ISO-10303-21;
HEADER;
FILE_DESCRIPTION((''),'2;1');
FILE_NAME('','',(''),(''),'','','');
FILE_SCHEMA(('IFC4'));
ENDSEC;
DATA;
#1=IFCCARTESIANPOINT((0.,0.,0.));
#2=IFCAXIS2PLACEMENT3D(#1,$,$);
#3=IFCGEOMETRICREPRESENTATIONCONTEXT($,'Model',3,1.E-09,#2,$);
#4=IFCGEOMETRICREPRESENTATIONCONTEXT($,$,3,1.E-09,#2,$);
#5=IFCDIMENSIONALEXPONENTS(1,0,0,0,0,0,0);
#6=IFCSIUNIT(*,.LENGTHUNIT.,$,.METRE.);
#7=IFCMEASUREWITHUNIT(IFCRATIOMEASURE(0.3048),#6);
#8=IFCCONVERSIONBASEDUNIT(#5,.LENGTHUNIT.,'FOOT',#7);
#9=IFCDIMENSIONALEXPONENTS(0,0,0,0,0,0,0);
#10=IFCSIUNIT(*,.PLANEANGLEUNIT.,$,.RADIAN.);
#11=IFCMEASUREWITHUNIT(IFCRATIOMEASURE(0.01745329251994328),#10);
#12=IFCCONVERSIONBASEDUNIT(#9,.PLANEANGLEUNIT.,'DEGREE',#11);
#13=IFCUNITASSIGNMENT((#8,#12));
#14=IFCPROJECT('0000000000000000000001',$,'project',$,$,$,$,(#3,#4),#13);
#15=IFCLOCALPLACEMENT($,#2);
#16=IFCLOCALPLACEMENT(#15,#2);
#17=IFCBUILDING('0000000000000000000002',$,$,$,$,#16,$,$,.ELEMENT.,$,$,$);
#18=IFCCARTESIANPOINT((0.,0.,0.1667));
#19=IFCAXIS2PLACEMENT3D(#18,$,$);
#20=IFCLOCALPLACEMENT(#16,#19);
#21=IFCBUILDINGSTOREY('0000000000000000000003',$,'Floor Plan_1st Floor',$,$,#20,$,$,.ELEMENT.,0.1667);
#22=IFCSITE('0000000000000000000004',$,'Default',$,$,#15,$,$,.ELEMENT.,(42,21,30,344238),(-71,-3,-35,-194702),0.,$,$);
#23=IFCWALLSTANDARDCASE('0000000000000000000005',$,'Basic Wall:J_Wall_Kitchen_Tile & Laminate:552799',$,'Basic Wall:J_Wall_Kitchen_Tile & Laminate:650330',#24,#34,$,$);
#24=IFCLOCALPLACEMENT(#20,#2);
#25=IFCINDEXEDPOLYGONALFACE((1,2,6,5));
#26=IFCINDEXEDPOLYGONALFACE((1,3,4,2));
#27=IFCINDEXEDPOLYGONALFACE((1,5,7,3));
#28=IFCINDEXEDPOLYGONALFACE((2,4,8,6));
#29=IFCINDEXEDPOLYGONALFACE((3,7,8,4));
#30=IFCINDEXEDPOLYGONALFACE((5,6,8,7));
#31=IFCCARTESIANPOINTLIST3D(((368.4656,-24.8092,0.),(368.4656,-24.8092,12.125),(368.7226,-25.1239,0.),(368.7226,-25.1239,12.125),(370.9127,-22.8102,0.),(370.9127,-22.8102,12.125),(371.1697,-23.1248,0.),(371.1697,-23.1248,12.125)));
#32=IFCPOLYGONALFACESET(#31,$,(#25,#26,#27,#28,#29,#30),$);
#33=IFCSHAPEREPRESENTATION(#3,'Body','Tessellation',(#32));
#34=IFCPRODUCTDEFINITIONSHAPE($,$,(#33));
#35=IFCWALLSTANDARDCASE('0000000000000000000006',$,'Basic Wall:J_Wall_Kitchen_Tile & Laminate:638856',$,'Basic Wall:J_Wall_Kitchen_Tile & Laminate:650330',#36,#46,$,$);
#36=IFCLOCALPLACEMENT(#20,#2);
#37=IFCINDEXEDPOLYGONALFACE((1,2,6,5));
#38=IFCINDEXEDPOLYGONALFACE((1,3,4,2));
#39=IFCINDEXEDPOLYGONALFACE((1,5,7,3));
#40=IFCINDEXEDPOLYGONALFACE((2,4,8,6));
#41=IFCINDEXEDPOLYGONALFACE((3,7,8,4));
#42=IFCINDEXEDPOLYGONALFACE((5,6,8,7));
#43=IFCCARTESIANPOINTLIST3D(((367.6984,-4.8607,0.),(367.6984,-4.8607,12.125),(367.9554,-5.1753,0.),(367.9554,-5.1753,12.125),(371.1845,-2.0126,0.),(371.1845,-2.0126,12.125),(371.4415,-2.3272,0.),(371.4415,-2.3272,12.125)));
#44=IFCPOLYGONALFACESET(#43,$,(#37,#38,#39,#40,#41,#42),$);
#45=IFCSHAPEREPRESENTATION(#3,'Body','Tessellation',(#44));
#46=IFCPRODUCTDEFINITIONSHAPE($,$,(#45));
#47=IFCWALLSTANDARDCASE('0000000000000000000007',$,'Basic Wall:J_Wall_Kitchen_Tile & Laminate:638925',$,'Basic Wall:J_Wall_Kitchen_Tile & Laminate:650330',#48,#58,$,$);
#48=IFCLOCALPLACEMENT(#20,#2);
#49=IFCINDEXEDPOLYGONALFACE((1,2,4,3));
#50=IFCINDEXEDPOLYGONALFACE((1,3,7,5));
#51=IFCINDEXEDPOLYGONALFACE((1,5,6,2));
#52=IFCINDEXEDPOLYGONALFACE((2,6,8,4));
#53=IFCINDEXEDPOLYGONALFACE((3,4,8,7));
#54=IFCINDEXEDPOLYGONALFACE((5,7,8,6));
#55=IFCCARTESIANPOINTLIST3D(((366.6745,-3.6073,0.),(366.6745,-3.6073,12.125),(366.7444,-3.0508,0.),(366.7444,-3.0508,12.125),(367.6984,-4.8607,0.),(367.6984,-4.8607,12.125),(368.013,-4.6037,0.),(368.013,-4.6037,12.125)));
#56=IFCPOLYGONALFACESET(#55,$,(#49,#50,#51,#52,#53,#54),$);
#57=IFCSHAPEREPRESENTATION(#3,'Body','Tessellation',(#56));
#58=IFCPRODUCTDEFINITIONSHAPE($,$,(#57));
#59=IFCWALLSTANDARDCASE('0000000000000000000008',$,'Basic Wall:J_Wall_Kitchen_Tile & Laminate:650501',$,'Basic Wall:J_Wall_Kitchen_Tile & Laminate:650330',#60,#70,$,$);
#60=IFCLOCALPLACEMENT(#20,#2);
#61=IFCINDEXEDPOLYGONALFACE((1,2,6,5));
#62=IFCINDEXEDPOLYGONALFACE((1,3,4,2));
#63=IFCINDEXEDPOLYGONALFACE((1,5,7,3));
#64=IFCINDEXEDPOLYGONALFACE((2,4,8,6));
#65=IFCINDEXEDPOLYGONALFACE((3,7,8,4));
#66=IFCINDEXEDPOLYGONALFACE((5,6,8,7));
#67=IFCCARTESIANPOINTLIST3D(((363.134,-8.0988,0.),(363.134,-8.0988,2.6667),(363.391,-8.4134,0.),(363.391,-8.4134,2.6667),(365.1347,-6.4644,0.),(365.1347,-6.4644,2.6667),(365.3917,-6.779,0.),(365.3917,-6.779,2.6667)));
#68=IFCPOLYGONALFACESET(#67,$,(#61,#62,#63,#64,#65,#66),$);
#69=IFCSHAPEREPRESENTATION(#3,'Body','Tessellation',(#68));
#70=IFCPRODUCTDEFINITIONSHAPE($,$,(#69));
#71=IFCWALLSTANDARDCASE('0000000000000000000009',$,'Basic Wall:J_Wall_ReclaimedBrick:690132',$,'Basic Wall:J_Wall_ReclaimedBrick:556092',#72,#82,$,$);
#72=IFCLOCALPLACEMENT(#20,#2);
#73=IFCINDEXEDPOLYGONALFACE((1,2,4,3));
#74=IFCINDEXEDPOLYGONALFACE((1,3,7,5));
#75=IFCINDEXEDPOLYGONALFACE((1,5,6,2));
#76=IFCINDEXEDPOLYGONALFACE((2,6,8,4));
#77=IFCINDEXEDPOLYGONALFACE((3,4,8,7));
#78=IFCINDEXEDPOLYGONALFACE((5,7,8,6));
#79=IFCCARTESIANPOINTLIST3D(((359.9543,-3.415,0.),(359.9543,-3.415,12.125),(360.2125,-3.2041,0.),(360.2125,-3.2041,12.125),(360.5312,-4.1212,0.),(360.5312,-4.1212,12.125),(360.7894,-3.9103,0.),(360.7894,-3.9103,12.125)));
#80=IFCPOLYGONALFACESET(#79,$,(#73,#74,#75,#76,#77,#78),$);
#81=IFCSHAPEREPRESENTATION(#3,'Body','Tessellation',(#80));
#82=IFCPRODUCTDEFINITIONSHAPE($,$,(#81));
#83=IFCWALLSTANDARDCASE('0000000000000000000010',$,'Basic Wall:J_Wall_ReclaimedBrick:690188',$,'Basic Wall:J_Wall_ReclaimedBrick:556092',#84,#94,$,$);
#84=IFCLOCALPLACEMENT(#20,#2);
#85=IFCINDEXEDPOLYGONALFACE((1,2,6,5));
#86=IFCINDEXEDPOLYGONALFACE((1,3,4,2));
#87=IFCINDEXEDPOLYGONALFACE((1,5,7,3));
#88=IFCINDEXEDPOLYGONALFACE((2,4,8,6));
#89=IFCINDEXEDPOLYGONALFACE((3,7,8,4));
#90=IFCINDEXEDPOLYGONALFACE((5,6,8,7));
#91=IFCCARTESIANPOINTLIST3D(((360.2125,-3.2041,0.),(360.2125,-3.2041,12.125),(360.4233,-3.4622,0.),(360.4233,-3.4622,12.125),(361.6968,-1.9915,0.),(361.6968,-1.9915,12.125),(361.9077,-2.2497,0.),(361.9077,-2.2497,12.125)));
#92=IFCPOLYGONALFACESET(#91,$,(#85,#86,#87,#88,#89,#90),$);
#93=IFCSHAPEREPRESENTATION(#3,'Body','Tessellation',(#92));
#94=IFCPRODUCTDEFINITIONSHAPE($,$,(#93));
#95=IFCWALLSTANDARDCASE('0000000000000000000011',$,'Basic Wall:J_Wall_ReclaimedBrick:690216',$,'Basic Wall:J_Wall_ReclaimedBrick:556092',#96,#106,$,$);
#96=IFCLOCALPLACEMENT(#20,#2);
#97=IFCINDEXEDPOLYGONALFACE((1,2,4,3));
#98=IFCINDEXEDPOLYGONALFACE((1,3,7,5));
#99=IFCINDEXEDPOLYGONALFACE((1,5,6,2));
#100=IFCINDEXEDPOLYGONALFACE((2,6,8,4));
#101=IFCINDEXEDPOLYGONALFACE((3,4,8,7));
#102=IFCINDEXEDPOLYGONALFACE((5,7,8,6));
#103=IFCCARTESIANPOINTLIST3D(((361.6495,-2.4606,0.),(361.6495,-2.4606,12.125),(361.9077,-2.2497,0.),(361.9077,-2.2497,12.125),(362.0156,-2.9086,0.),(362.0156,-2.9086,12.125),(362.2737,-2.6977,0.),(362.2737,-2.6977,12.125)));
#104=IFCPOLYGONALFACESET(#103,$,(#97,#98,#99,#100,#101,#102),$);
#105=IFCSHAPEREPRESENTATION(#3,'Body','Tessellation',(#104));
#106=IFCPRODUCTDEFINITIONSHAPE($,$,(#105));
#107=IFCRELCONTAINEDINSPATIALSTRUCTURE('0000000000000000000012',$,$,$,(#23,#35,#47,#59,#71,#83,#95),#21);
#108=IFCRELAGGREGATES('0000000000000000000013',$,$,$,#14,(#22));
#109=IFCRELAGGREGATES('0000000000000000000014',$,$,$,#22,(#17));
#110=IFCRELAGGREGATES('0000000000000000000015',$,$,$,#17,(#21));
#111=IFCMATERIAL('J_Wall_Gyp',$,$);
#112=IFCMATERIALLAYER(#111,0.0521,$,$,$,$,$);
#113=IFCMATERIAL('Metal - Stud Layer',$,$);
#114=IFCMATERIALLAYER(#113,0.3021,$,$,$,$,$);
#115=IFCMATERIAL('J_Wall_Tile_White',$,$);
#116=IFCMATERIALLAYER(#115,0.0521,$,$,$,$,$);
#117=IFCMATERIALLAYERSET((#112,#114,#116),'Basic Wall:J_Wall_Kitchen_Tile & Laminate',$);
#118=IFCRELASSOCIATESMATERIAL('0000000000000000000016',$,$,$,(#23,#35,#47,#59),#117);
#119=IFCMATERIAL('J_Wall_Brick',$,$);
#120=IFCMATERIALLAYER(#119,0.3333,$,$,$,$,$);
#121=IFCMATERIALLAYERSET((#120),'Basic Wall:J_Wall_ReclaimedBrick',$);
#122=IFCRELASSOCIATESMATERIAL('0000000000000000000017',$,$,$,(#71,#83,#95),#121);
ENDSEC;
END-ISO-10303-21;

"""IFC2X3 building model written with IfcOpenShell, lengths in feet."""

from ifc_helpers import new_model, entity, si_unit, converted_unit, frame, frame_2d, origin, place, context, project, spatial, polyline, rectangle, outline, extrude, material, layer, layer_set, layer_usage, element, save


model = new_model("IFC2X3")

# Units and contexts
model_context = context("Model", 3, precision=1e-09, world=origin())
context_of_model = context(None, 3, precision=1e-09, world=origin())
ifc_project = project(units=[converted_unit("LENGTHUNIT", "FOOT", entity("IfcRatioMeasure", 0.3048), si_unit("LENGTHUNIT", "METRE"), dimensions=[1, 0, 0, 0, 0, 0, 0]), converted_unit("PLANEANGLEUNIT", "DEGREE", entity("IfcRatioMeasure", 0.01745329251994328), si_unit("PLANEANGLEUNIT", "RADIAN"), dimensions=[0, 0, 0, 0, 0, 0, 0])], contexts=[model_context, context_of_model])

# Site, building, storey
site_placement = place(None, origin())
site = spatial("IfcSite", under=ifc_project, at=site_placement, Name="Default", CompositionType="ELEMENT", RefLatitude=(42, 21, 30, 344238), RefLongitude=(-71, -3, -35, -194702), RefElevation=0.0)
building_placement = place(site_placement, origin())
building = spatial("IfcBuilding", under=site, at=building_placement, CompositionType="ELEMENT")
storey_placement = place(building_placement, frame((0.0, 0.0, 0.1667)))
storey = spatial("IfcBuildingStorey", under=building, at=storey_placement, Name="Floor Plan_1st Floor", CompositionType="ELEMENT", Elevation=0.1667)

# Shared definitions
ifc_material_1 = material(Name="J_Wall_Gyp")
ifc_layer_1 = layer(ifc_material_1, 0.0521)
ifc_material_2 = material(Name="Metal - Stud Layer")
ifc_layer_2 = layer(ifc_material_2, 0.3021)
ifc_material_3 = material(Name="J_Wall_Tile_White")
ifc_layer_3 = layer(ifc_material_3, 0.0521)
ifc_layer_set_1 = layer_set([ifc_layer_1, ifc_layer_2, ifc_layer_3], Name="Basic Wall:J_Wall_Kitchen_Tile & Laminate")

# Shared definitions
ifc_material_4 = material(Name="J_Wall_Brick")
ifc_layer_4 = layer(ifc_material_4, 0.3333)
ifc_layer_set_2 = layer_set([ifc_layer_4], Name="Basic Wall:J_Wall_ReclaimedBrick")

# Walls
ifc_layer_usage_1 = layer_usage(ifc_layer_set_1, "AXIS2", "POSITIVE", -0.2031)
wall_1_placement = place(storey_placement, frame((371.0412, -22.9675, 0.0), z_axis=(0.0, 0.0, 1.0), x_axis=(-0.774444, -0.632643, 0.0)))
element("IfcWallStandardCase", 1, at=wall_1_placement, inside=storey, material=ifc_layer_usage_1, Name="Basic Wall:J_Wall_Kitchen_Tile & Laminate:552799", ObjectType="Basic Wall:J_Wall_Kitchen_Tile & Laminate:650330", context=model_context, shape_type="SweptSolid", body=[
    extrude(rectangle(XDim=3.1598, YDim=0.4063, at=frame_2d((1.5799, 0.0), x_axis=(-1.0, 0.0))), origin(), (0.0, 0.0, 1.0), 12.125),
])
ifc_layer_usage_2 = layer_usage(ifc_layer_set_1, "AXIS2", "POSITIVE", -0.2031)
wall_2_placement = place(storey_placement, frame((371.313, -2.1699, 0.0), z_axis=(0.0, 0.0, 1.0), x_axis=(-0.774414, -0.63268, 0.0)))
element("IfcWallStandardCase", 2, at=wall_2_placement, inside=storey, material=ifc_layer_usage_2, Name="Basic Wall:J_Wall_Kitchen_Tile & Laminate:638856", ObjectType="Basic Wall:J_Wall_Kitchen_Tile & Laminate:650330", context=model_context, shape_type="SweptSolid", body=[
    extrude(rectangle(XDim=4.5016, YDim=0.4063, at=frame_2d((2.2508, 0.0), x_axis=(-1.0, 0.0))), origin(), (0.0, 0.0, 1.0), 12.125),
])
ifc_layer_usage_3 = layer_usage(ifc_layer_set_1, "AXIS2", "NEGATIVE", 0.2031)
wall_3_placement = place(storey_placement, frame((366.5871, -3.1793, 0.0), z_axis=(0.0, 0.0, 1.0), x_axis=(0.632643, -0.774444, 0.0)))
element("IfcWallStandardCase", 3, at=wall_3_placement, inside=storey, material=ifc_layer_usage_3, Name="Basic Wall:J_Wall_Kitchen_Tile & Laminate:638925", ObjectType="Basic Wall:J_Wall_Kitchen_Tile & Laminate:650330", context=model_context, shape_type="SweptSolid", body=[
    extrude(outline(polyline([(2.0051, -0.2031), (2.0051, 0.2031), (0.0, 0.2031), (0.3867, -0.2031), (2.0051, -0.2031)])), origin(), (0.0, 0.0, 1.0), 12.125),
])
ifc_layer_usage_4 = layer_usage(ifc_layer_set_1, "AXIS2", "POSITIVE", -0.2031)
wall_4_placement = place(storey_placement, frame((365.2632, -6.6217, 0.0), z_axis=(0.0, 0.0, 1.0), x_axis=(-0.774444, -0.632643, 0.0)))
element("IfcWallStandardCase", 4, at=wall_4_placement, inside=storey, material=ifc_layer_usage_4, Name="Basic Wall:J_Wall_Kitchen_Tile & Laminate:650501", ObjectType="Basic Wall:J_Wall_Kitchen_Tile & Laminate:650330", context=model_context, shape_type="SweptSolid", body=[
    extrude(rectangle(XDim=2.5834, YDim=0.4063, at=frame_2d((1.2917, 0.0), x_axis=(-1.0, 0.0))), origin(), (0.0, 0.0, 1.0), 2.6667),
])
ifc_layer_usage_5 = layer_usage(ifc_layer_set_2, "AXIS2", "NEGATIVE", 0.1667)
wall_5_placement = place(storey_placement, frame((360.6603, -4.0157, 0.0), z_axis=(0.0, 0.0, 1.0), x_axis=(-0.632643, 0.774444, 0.0)))
element("IfcWallStandardCase", 5, at=wall_5_placement, inside=storey, material=ifc_layer_usage_5, Name="Basic Wall:J_Wall_ReclaimedBrick:690132", ObjectType="Basic Wall:J_Wall_ReclaimedBrick:556092", context=model_context, shape_type="SweptSolid", body=[
    extrude(rectangle(XDim=0.9119, YDim=0.3333, at=frame_2d((0.4559, 0.0), x_axis=(-1.0, 0.0))), origin(), (0.0, 0.0, 1.0), 12.125),
])
ifc_layer_usage_6 = layer_usage(ifc_layer_set_2, "AXIS2", "NEGATIVE", 0.1667)
wall_6_placement = place(storey_placement, frame((360.3179, -3.3332, 0.0), z_axis=(0.0, 0.0, 1.0), x_axis=(0.774444, 0.632643, 0.0)))
element("IfcWallStandardCase", 6, at=wall_6_placement, inside=storey, material=ifc_layer_usage_6, Name="Basic Wall:J_Wall_ReclaimedBrick:690188", ObjectType="Basic Wall:J_Wall_ReclaimedBrick:556092", context=model_context, shape_type="SweptSolid", body=[
    extrude(rectangle(XDim=1.9167, YDim=0.3333, at=frame_2d((0.9583, 0.0), x_axis=(-1.0, 0.0))), origin(), (0.0, 0.0, 1.0), 12.125),
])
ifc_layer_usage_7 = layer_usage(ifc_layer_set_2, "AXIS2", "NEGATIVE", 0.1667)
wall_7_placement = place(storey_placement, frame((361.7786, -2.3551, 0.0), z_axis=(0.0, 0.0, 1.0), x_axis=(0.632643, -0.774444, 0.0)))
element("IfcWallStandardCase", 7, at=wall_7_placement, inside=storey, material=ifc_layer_usage_7, Name="Basic Wall:J_Wall_ReclaimedBrick:690216", ObjectType="Basic Wall:J_Wall_ReclaimedBrick:556092", context=model_context, shape_type="SweptSolid", body=[
    extrude(rectangle(XDim=0.5786, YDim=0.3333, at=frame_2d((0.2893, 0.0), x_axis=(-1.0, 0.0))), origin(), (0.0, 0.0, 1.0), 12.125),
])

save(model, "model.ifc")
